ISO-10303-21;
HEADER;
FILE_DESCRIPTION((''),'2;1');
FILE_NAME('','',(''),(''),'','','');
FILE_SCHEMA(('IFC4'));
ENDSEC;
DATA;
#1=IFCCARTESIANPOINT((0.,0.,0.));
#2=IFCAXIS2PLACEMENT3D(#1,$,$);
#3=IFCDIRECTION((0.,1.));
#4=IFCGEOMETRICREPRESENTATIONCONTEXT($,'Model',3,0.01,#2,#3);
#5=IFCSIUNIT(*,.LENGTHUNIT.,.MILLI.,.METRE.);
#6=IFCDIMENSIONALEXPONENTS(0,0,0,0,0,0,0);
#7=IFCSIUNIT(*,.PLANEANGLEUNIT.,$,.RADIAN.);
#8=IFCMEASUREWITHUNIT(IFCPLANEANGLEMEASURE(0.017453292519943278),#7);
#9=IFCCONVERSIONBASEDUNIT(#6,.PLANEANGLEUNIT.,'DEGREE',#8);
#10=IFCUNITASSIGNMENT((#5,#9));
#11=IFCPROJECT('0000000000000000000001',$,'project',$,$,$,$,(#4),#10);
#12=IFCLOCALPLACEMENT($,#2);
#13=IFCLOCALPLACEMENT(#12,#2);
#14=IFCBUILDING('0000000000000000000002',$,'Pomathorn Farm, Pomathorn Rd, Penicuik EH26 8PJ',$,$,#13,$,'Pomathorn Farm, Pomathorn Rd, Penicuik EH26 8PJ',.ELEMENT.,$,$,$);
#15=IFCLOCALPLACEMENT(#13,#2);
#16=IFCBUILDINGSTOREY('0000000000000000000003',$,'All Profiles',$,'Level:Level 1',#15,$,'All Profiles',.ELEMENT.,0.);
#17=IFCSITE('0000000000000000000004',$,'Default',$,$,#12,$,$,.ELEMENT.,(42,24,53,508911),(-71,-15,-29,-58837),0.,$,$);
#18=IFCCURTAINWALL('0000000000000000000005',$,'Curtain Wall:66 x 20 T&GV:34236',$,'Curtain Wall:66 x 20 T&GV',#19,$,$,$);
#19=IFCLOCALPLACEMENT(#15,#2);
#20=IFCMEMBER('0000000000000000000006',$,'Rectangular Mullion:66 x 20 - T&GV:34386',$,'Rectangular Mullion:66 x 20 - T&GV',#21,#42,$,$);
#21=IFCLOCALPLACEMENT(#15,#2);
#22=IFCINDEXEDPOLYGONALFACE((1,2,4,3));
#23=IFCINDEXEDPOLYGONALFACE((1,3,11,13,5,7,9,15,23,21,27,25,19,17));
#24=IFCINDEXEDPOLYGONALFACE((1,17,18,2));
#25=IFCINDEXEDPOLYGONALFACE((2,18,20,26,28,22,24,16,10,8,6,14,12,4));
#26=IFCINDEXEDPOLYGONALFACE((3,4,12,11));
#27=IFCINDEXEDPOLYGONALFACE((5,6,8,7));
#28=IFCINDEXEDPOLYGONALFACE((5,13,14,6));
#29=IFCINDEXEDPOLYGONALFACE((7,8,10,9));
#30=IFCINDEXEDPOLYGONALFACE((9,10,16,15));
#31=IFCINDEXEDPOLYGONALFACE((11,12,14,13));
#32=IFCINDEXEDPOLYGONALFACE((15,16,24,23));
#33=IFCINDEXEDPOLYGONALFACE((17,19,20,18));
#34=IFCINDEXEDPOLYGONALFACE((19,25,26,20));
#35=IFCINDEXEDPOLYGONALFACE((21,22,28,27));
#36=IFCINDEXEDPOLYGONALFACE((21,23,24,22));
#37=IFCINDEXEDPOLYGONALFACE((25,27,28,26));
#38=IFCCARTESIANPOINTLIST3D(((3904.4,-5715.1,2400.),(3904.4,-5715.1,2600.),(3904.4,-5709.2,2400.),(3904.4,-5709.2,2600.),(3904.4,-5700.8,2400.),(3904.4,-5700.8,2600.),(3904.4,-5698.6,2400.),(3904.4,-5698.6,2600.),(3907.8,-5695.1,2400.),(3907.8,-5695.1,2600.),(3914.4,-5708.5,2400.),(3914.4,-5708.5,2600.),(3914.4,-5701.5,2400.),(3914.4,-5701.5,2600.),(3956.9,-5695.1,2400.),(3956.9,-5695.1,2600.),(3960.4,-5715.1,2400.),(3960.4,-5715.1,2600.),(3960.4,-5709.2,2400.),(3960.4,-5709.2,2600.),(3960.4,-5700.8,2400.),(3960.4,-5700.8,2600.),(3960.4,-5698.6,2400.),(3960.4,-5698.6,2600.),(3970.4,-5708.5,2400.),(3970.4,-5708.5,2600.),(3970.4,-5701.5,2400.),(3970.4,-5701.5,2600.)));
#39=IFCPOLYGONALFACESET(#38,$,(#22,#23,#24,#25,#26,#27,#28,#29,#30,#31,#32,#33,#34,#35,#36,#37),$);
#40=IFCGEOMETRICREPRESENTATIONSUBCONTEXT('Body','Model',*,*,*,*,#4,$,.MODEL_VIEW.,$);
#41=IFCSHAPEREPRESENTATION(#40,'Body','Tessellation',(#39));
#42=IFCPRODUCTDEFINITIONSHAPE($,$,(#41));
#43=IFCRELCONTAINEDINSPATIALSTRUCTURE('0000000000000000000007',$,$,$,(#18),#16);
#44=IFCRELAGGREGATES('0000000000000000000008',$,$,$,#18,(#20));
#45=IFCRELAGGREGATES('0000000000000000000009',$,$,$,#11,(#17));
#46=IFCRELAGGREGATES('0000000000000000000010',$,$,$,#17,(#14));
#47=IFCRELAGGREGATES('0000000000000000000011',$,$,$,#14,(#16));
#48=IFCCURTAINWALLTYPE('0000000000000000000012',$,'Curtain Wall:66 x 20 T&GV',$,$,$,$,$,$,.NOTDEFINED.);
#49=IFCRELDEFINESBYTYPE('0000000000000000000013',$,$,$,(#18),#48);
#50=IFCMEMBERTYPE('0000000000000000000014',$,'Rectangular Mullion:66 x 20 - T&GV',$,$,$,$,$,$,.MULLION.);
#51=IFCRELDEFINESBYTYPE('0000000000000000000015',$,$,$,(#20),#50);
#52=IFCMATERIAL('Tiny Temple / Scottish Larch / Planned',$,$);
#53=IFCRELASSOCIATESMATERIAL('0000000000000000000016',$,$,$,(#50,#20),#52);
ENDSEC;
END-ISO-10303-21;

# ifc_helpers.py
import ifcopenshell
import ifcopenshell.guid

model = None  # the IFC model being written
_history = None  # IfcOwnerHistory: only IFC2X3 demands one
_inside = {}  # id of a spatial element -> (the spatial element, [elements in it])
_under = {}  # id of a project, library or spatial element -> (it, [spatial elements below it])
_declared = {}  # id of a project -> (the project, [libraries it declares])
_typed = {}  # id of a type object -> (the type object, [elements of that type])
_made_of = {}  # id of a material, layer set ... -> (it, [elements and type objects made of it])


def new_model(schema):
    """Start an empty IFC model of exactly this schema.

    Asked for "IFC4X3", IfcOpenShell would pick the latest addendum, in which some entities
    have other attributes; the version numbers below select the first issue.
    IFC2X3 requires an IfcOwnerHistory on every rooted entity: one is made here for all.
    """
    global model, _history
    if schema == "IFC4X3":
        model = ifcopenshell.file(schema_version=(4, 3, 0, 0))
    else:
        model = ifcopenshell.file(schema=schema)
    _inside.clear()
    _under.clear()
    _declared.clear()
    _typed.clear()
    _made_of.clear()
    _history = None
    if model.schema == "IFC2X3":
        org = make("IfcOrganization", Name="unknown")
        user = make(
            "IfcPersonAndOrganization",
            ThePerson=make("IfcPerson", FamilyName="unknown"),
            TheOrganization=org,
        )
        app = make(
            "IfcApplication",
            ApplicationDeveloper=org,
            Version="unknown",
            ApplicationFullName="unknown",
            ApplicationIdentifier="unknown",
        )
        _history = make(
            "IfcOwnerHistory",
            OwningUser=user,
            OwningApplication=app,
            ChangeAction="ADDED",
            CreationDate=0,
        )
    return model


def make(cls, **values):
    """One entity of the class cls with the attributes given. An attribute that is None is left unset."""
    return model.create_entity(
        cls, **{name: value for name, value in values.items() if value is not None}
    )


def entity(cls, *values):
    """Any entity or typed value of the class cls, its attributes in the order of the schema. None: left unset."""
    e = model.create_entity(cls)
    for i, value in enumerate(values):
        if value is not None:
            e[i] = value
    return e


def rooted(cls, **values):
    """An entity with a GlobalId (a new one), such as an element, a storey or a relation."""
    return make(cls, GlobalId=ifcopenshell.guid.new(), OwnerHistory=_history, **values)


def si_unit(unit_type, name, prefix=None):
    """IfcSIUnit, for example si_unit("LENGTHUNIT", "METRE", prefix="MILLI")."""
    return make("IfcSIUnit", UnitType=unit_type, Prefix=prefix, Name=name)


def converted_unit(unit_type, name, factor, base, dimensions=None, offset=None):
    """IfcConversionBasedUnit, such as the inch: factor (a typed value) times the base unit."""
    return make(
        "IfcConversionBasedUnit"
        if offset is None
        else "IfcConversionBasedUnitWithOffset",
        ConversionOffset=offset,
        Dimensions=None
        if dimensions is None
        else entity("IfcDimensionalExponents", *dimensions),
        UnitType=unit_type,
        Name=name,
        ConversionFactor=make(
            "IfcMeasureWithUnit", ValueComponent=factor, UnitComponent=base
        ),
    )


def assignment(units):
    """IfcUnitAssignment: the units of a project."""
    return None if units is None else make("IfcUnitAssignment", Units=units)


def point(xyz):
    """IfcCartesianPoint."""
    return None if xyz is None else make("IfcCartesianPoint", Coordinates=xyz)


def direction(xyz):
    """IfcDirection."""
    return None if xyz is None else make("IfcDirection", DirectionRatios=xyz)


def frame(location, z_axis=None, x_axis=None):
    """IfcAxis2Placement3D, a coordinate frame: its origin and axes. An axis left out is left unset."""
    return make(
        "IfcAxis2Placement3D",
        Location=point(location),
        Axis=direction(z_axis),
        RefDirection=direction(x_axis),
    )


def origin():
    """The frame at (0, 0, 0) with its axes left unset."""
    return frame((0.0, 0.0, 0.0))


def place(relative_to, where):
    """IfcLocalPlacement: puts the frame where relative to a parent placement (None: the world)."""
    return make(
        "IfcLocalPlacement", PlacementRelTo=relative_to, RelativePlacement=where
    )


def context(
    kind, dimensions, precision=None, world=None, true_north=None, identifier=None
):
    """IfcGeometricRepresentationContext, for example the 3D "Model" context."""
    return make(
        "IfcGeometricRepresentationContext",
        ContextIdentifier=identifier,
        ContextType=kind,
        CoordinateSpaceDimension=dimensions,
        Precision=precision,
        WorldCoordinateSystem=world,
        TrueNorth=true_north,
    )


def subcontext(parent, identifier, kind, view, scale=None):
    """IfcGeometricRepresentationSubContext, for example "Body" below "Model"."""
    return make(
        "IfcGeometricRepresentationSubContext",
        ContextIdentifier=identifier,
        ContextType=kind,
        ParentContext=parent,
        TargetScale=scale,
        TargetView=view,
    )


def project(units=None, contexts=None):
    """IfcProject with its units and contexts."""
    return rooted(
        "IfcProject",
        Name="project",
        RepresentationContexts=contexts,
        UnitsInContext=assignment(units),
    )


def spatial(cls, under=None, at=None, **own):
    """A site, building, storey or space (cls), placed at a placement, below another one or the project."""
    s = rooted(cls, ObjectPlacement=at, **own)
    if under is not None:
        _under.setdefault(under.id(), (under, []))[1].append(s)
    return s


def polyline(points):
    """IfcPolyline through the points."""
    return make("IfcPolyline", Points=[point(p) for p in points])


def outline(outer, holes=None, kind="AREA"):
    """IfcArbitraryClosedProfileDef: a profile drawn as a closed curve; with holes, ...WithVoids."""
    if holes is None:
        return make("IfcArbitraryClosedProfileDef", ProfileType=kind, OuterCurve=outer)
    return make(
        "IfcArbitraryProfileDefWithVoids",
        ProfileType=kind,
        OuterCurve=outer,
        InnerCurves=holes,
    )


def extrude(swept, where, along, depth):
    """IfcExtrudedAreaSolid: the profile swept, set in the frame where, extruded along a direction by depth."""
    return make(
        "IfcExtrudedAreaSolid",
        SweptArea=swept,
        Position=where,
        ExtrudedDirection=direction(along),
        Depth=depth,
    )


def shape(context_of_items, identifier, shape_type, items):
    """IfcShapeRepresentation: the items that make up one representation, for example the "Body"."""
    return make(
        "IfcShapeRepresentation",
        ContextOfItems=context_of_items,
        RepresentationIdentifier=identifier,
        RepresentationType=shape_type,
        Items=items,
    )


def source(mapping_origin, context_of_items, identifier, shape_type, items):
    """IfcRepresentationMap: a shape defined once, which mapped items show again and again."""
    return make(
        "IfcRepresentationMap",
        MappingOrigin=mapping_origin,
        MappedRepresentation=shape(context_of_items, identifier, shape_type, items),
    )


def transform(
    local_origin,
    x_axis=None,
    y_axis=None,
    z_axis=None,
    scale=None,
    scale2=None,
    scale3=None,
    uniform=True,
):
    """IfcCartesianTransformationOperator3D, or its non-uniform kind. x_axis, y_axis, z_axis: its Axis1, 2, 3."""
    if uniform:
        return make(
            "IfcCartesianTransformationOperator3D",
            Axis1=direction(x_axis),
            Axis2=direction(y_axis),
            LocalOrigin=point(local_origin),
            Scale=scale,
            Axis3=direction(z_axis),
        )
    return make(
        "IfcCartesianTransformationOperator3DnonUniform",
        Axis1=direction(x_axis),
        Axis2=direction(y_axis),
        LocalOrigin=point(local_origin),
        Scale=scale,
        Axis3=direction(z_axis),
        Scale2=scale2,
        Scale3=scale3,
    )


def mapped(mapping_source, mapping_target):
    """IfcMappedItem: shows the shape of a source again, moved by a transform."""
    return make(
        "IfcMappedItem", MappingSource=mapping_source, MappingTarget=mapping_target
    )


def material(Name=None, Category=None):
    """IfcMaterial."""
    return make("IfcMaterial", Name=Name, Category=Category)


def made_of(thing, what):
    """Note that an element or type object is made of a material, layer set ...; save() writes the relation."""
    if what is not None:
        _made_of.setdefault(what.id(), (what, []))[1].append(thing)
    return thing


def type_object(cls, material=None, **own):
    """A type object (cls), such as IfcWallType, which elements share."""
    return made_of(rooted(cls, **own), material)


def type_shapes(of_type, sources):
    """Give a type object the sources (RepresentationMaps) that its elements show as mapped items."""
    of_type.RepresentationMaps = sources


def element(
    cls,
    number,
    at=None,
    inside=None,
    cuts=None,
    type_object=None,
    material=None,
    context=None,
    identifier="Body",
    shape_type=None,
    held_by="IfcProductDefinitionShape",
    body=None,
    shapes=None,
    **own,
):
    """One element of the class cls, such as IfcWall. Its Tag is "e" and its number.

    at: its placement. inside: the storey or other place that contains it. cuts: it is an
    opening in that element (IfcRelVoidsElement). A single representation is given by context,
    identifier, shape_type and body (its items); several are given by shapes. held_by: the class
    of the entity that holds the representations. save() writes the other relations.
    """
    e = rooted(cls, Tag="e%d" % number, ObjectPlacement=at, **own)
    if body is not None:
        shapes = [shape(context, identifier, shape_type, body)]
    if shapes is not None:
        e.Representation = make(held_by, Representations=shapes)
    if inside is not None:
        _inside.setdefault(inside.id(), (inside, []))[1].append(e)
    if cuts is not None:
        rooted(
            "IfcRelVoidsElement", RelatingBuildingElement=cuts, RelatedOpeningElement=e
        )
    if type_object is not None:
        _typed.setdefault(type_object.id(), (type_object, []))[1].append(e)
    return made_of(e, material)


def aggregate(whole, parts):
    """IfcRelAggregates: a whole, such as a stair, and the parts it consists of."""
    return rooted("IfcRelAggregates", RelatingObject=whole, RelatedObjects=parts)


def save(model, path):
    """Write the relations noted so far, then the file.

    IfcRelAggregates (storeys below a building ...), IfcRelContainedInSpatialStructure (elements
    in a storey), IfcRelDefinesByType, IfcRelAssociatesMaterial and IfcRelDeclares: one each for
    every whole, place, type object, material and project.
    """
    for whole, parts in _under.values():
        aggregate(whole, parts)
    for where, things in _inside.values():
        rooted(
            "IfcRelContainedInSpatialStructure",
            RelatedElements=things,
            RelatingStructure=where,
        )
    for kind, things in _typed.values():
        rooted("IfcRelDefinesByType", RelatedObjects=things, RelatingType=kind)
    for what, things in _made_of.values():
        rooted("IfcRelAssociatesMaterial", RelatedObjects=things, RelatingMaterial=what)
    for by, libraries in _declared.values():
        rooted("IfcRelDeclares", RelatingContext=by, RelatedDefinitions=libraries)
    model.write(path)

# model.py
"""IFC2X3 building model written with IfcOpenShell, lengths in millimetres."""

from ifc_helpers import new_model, entity, si_unit, converted_unit, direction, frame, origin, place, context, subcontext, project, spatial, polyline, outline, extrude, source, transform, mapped, material, type_object, type_shapes, element, aggregate, save


model = new_model("IFC2X3")

# Units and contexts
model_context = context("Model", 3, precision=0.01, world=origin(), true_north=direction((0.0, 1.0)))
body_context = subcontext(model_context, "Body", "Model", "MODEL_VIEW")
ifc_project = project(units=[si_unit("LENGTHUNIT", "METRE", prefix="MILLI"), converted_unit("PLANEANGLEUNIT", "DEGREE", entity("IfcPlaneAngleMeasure", 0.017453292519943278), si_unit("PLANEANGLEUNIT", "RADIAN"), dimensions=[0, 0, 0, 0, 0, 0, 0])], contexts=[model_context])

# Site, building, storey
site_placement = place(None, origin())
site = spatial("IfcSite", under=ifc_project, at=site_placement, Name="Default", CompositionType="ELEMENT", RefLatitude=(42, 24, 53, 508911), RefLongitude=(-71, -15, -29, -58837), RefElevation=0.0)
building_placement = place(site_placement, origin())
building = spatial("IfcBuilding", under=site, at=building_placement, Name="Pomathorn Farm, Pomathorn Rd, Penicuik EH26 8PJ", LongName="Pomathorn Farm, Pomathorn Rd, Penicuik EH26 8PJ", CompositionType="ELEMENT")
storey_placement = place(building_placement, origin())
storey = spatial("IfcBuildingStorey", under=building, at=storey_placement, Name="All Profiles", ObjectType="Level:Level 1", LongName="All Profiles", CompositionType="ELEMENT", Elevation=0.0)

# Curtain wall, member
curtain_wall_type = type_object("IfcCurtainWallType", Name="Curtain Wall:66 x 20 T&GV", PredefinedType="NOTDEFINED")
curtain_wall_placement = place(storey_placement, origin())
curtain_wall = element("IfcCurtainWall", 1, at=curtain_wall_placement, inside=storey, type_object=curtain_wall_type, Name="Curtain Wall:66 x 20 T&GV:34236", ObjectType="Curtain Wall:66 x 20 T&GV")
ifc_material = material(Name="Tiny Temple / Scottish Larch / Planned")
member_type = type_object("IfcMemberType", Name="Rectangular Mullion:66 x 20 - T&GV", PredefinedType="MULLION", material=ifc_material)
shared_shape = source(origin(), body_context, "Body", "SweptSolid", [
    extrude(outline(polyline([(-25.1, -11.0), (30.9, -11.0), (30.9, -5.1), (20.9, -4.4), (20.9, 2.6), (30.9, 3.3), (30.9, 5.5), (27.4, 9.0), (-21.7, 9.0), (-25.1, 5.5), (-25.1, 3.3), (-35.1, 2.6), (-35.1, -4.4), (-25.1, -5.1), (-25.1, -11.0)])), frame((-35.1, -11.0, -200.0), z_axis=(0.0, 0.0, 1.0), x_axis=(-1.0, 0.0, 0.0)), (0.0, 0.0, 1.0), 200.0),
])
type_shapes(member_type, [shared_shape])
member_1_placement = place(curtain_wall_placement, frame((3970.4, -5715.1, 2400.0), z_axis=(0.0, 0.0, -1.0), x_axis=(1.0, 0.0, 0.0)))
member_1 = element("IfcMember", 2, at=member_1_placement, type_object=member_type, material=ifc_material, Name="Rectangular Mullion:66 x 20 - T&GV:34386", ObjectType="Rectangular Mullion:66 x 20 - T&GV", context=body_context, shape_type="MappedRepresentation", body=[
    mapped(shared_shape, transform((0.0, 0.0, 0.0), scale=1.0)),
])
aggregate(curtain_wall, [member_1])

save(model, "model.ifc")
